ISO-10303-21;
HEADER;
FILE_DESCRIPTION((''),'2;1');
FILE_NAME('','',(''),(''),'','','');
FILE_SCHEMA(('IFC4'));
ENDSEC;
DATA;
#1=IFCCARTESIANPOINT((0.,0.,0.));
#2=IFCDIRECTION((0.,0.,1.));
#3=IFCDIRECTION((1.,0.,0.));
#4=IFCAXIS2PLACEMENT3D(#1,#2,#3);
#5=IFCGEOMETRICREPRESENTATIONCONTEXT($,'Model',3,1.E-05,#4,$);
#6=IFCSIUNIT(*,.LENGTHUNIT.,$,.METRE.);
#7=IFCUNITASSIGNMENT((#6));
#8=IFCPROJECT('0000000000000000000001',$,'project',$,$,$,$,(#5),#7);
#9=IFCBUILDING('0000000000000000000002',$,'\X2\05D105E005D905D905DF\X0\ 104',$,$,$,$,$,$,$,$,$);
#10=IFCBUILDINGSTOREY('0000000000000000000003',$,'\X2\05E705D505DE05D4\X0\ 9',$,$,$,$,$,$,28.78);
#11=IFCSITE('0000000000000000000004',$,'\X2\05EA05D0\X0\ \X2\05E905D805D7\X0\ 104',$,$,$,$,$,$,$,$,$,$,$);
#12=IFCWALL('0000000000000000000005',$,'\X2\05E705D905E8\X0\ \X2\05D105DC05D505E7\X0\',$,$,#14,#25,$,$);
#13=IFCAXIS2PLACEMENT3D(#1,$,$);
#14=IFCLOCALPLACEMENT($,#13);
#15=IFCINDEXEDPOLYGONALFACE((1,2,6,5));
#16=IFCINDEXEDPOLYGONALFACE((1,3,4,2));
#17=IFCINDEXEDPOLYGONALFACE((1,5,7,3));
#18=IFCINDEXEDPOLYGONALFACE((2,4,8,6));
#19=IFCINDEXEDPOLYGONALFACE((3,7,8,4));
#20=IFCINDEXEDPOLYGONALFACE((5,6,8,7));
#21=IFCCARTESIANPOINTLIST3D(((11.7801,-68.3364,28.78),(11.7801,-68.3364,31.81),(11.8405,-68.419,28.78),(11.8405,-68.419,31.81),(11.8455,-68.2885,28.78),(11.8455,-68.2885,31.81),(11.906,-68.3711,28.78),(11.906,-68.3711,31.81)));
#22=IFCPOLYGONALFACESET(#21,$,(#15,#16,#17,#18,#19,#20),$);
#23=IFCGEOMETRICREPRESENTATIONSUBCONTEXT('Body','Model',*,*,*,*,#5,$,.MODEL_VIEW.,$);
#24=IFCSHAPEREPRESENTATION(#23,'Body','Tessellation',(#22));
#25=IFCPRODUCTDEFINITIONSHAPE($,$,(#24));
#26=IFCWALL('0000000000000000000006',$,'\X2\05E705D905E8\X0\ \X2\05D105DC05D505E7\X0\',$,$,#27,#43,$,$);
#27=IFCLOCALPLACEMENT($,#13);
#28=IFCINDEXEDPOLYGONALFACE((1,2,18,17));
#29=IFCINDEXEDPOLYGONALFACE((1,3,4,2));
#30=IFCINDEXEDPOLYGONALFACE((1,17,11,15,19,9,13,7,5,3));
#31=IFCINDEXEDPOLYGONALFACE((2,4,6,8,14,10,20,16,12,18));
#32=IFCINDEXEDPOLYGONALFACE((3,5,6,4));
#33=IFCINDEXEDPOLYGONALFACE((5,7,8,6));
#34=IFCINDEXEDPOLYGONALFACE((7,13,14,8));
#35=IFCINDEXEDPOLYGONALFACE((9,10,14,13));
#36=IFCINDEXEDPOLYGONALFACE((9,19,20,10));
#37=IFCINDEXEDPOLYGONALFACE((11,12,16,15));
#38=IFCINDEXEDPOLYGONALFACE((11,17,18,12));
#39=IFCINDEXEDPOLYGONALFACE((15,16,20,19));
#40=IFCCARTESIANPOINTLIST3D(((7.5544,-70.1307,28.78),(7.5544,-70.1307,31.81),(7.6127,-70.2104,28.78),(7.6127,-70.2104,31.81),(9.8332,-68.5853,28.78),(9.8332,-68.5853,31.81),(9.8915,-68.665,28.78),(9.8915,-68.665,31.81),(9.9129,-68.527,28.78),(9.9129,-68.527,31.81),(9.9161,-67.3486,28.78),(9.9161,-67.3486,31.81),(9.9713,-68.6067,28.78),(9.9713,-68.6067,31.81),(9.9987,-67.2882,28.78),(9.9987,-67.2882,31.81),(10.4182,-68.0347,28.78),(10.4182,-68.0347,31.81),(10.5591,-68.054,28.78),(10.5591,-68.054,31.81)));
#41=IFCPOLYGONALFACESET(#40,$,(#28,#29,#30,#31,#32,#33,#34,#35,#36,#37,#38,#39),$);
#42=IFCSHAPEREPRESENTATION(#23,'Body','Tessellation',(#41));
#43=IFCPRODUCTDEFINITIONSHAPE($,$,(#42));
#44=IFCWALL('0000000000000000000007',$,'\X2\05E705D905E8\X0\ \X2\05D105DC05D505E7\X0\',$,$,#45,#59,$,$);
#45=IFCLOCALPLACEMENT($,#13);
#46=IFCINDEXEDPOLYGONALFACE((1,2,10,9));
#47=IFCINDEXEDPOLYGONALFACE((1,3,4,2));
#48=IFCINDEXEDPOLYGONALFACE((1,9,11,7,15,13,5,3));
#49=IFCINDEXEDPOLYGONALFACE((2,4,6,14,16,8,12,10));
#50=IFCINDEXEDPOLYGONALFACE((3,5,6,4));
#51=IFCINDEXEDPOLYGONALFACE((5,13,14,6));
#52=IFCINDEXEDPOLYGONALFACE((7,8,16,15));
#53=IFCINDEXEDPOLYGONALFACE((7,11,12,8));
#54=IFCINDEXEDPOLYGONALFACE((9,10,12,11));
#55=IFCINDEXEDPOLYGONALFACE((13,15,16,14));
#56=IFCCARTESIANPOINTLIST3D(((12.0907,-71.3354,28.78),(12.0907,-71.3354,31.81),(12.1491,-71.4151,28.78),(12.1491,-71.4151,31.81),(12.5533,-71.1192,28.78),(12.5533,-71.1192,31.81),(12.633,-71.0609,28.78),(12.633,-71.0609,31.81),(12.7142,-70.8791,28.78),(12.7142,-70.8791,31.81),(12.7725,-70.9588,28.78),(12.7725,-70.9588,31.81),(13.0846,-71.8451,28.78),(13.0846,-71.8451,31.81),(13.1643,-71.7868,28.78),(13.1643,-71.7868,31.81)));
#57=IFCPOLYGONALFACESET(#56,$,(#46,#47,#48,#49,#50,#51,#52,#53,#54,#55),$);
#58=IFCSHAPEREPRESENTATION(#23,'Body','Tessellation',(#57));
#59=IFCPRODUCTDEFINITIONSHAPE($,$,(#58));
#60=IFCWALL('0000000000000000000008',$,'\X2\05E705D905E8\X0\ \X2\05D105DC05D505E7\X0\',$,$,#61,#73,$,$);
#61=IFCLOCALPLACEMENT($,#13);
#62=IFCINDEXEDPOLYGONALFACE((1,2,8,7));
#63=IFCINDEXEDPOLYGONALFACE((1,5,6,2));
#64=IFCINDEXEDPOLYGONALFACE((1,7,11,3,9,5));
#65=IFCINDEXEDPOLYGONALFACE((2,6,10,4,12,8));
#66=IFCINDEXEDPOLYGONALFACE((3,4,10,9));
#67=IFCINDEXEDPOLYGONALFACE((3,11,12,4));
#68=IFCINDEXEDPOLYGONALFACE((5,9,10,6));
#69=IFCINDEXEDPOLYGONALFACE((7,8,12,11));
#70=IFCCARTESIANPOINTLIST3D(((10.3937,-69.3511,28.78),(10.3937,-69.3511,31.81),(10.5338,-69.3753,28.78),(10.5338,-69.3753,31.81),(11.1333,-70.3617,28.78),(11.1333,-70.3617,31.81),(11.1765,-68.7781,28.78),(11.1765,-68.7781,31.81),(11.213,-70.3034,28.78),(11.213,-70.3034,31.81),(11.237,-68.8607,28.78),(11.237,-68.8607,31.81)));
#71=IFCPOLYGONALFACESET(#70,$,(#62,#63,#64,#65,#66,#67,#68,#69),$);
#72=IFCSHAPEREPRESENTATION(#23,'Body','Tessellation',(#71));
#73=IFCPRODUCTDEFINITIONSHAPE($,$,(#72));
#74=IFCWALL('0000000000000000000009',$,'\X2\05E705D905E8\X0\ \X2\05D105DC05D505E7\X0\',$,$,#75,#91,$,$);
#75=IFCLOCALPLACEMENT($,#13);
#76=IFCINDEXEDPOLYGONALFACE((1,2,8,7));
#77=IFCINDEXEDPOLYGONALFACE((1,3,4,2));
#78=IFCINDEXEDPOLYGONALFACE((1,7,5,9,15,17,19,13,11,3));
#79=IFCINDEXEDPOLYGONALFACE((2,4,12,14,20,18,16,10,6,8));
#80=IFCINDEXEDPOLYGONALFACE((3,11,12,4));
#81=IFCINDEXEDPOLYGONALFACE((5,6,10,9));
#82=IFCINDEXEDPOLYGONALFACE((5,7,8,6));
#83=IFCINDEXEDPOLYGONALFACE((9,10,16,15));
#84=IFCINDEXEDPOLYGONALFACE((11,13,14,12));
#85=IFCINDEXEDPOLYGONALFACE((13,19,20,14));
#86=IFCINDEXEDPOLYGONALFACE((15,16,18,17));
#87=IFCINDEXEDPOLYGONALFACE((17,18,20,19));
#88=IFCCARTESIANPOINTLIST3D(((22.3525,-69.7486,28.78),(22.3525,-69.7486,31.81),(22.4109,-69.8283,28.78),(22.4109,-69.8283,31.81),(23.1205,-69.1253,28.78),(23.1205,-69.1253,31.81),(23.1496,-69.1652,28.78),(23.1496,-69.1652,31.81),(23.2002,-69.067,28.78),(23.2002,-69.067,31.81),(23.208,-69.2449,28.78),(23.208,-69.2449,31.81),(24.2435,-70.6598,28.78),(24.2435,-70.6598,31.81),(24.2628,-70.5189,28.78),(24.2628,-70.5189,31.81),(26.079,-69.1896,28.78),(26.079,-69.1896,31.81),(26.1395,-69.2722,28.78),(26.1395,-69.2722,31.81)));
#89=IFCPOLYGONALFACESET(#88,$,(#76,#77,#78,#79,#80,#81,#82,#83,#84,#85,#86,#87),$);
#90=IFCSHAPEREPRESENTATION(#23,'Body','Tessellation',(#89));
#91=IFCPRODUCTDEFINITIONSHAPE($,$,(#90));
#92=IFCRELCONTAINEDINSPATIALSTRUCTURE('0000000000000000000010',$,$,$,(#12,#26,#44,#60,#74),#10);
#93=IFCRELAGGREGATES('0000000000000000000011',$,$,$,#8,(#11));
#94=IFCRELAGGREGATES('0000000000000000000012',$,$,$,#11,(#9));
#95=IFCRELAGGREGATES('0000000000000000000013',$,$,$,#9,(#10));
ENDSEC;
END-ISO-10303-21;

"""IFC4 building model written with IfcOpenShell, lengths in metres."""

from ifc_helpers import new_model, si_unit, frame, origin_with_axes, context, subcontext, project, spatial, polyline, outline, extrude, element, save


model = new_model("IFC4")

# Units and contexts
model_context = context("Model", 3, precision=1e-05, world=origin_with_axes())
body_context = subcontext(model_context, "Body", "Model", "MODEL_VIEW")
ifc_project = project(units=[si_unit("LENGTHUNIT", "METRE")], contexts=[model_context])

# Site, building, storey
site = spatial("IfcSite", under=ifc_project, Name="תא שטח 104")
building = spatial("IfcBuilding", under=site, Name="בניין 104")
storey = spatial("IfcBuildingStorey", under=building, Name="קומה 9", Elevation=28.78)

# Walls
element("IfcWall", 1, inside=storey, Name="קיר בלוק", context=body_context, shape_type="SweptSolid", body=[
    extrude(outline(polyline([(11.906, -68.3711), (11.8455, -68.2885), (11.7801, -68.3364), (11.8405, -68.419), (11.906, -68.3711)])), frame((0.0, 0.0, 28.78)), (0.0, 0.0, 1.0), 3.03),
])
element("IfcWall", 2, inside=storey, Name="קיר בלוק", context=body_context, shape_type="SweptSolid", body=[
    extrude(outline(polyline([(10.4182, -68.0347), (7.5544, -70.1307), (7.6127, -70.2104), (9.8332, -68.5853), (9.8915, -68.665), (9.9713, -68.6067), (9.9129, -68.527), (10.5591, -68.054), (9.9987, -67.2882), (9.9161, -67.3486), (10.4182, -68.0347)])), frame((0.0, 0.0, 28.78)), (0.0, 0.0, 1.0), 3.03),
])
element("IfcWall", 3, inside=storey, Name="קיר בלוק", context=body_context, shape_type="SweptSolid", body=[
    extrude(outline(polyline([(12.633, -71.0609), (12.7725, -70.9588), (12.7142, -70.8791), (12.0907, -71.3354), (12.1491, -71.4151), (12.5533, -71.1192), (13.0846, -71.8451), (13.1643, -71.7868), (12.633, -71.0609)])), frame((0.0, 0.0, 28.78)), (0.0, 0.0, 1.0), 3.03),
])
element("IfcWall", 4, inside=storey, Name="קיר בלוק", context=body_context, shape_type="SweptSolid", body=[
    extrude(outline(polyline([(10.3937, -69.3511), (11.1333, -70.3617), (11.213, -70.3034), (10.5338, -69.3753), (11.237, -68.8607), (11.1765, -68.7781), (10.3937, -69.3511)])), frame((0.0, 0.0, 28.78)), (0.0, 0.0, 1.0), 3.03),
])
element("IfcWall", 5, inside=storey, Name="קיר בלוק", context=body_context, shape_type="SweptSolid", body=[
    extrude(outline(polyline([(23.1205, -69.1253), (23.1496, -69.1652), (22.3525, -69.7486), (22.4109, -69.8283), (23.208, -69.2449), (24.2435, -70.6598), (26.1395, -69.2722), (26.079, -69.1896), (24.2628, -70.5189), (23.2002, -69.067), (23.1205, -69.1253)])), frame((0.0, 0.0, 28.78)), (0.0, 0.0, 1.0), 3.03),
])

save(model, "model.ifc")
